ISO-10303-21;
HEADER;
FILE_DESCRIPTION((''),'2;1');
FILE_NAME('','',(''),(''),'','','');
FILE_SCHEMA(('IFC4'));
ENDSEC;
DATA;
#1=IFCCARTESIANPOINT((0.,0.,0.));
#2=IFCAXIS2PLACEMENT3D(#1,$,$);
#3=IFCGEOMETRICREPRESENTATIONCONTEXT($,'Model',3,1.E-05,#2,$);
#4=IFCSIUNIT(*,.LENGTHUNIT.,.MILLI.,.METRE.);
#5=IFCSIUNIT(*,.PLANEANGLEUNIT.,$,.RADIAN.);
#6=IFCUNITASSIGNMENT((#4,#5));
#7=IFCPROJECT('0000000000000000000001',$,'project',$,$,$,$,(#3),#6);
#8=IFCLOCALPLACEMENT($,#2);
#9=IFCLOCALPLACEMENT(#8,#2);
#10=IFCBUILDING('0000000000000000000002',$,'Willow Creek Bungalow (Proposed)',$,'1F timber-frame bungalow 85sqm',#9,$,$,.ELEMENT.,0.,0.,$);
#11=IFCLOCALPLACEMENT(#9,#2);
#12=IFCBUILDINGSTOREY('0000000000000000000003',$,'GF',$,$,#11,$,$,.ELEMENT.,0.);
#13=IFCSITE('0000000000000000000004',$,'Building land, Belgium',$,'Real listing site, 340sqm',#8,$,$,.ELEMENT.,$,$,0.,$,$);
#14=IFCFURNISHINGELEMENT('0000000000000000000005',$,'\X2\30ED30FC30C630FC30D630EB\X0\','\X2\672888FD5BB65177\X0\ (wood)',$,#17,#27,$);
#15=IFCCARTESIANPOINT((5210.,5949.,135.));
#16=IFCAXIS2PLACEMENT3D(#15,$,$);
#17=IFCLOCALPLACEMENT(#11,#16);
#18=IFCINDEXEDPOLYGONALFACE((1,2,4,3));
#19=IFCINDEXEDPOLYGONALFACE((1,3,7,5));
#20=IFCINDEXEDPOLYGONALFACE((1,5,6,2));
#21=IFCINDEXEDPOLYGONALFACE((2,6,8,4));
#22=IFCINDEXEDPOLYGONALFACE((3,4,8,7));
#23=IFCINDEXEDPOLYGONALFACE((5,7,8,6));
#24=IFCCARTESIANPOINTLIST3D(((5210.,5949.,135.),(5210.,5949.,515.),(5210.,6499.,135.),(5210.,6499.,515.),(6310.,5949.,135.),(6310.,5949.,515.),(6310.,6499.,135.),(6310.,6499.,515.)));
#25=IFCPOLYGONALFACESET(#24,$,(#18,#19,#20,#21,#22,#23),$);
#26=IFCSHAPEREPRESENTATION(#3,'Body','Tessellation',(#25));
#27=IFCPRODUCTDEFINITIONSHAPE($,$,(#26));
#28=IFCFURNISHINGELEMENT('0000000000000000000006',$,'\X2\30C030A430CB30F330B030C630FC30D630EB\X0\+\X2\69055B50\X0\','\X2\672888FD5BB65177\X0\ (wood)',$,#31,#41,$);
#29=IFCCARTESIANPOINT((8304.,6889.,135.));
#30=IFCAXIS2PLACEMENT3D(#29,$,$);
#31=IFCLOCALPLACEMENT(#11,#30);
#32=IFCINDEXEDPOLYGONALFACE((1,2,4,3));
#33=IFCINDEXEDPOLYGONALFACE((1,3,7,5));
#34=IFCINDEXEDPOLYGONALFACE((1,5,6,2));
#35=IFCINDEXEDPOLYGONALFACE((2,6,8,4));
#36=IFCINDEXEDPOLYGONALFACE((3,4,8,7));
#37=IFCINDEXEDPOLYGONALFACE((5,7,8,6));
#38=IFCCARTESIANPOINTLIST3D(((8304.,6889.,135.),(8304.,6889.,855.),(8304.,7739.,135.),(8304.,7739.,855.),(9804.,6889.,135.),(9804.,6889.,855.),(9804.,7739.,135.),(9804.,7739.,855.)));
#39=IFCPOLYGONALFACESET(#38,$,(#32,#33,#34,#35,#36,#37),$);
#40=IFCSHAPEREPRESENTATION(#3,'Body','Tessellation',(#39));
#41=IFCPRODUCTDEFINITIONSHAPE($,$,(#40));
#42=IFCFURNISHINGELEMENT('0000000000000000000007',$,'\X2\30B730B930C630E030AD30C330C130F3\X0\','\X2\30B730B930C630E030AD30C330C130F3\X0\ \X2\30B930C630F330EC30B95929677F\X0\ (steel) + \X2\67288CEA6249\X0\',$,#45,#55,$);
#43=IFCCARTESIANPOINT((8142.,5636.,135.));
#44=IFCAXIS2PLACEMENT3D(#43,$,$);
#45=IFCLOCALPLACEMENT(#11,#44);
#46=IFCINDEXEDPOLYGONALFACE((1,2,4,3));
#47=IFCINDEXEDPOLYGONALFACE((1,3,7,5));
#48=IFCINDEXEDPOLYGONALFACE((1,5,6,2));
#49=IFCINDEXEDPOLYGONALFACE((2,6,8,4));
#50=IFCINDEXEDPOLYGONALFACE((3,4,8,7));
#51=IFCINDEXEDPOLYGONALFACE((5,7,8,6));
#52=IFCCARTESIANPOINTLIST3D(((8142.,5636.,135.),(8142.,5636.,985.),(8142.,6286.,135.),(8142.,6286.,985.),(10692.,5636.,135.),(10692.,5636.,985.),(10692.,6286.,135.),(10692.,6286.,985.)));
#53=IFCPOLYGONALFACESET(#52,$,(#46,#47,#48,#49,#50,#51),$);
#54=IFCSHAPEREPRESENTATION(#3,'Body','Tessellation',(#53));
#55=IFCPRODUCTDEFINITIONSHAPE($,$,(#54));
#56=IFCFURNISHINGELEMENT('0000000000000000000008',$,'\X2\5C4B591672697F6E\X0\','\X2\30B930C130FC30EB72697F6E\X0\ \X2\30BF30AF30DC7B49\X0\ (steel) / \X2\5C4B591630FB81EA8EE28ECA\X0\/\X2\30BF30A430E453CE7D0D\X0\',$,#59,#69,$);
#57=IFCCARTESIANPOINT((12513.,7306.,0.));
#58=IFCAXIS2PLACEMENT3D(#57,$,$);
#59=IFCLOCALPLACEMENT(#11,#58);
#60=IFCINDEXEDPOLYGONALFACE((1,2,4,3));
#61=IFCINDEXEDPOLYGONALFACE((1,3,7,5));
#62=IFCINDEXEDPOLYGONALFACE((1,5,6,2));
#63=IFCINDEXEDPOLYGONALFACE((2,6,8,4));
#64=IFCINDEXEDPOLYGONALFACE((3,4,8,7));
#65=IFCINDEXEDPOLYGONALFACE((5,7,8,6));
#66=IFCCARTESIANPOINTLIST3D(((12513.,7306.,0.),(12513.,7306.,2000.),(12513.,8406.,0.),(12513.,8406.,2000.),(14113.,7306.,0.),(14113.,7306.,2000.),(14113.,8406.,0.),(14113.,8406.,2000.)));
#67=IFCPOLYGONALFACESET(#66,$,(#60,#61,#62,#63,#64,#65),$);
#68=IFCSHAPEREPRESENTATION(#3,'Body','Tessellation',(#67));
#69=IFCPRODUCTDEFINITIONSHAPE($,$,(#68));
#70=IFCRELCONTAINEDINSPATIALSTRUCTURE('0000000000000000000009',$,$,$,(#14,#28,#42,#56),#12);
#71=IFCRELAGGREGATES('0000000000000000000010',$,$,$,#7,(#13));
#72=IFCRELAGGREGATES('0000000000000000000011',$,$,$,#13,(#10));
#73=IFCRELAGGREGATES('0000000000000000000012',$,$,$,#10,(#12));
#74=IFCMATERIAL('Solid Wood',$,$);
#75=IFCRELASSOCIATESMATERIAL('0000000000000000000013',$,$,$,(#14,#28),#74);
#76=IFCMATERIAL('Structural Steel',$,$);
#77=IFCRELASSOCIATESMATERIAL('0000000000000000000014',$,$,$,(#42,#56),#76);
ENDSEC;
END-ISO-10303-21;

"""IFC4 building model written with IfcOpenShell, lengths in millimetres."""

from ifc_helpers import new_model, si_unit, frame, frame_2d, origin, place, context, project, spatial, rectangle, extrude, material, element, save


model = new_model("IFC4")

# Units and contexts
model_context = context("Model", 3, precision=1e-05, world=origin())
ifc_project = project(units=[si_unit("LENGTHUNIT", "METRE", prefix="MILLI"), si_unit("PLANEANGLEUNIT", "RADIAN")], contexts=[model_context])

# Site, building, storey
site_placement = place(None, origin())
site = spatial("IfcSite", under=ifc_project, at=site_placement, Name="Building land, Belgium", ObjectType="Real listing site, 340sqm", CompositionType="ELEMENT", RefElevation=0.0)
building_placement = place(site_placement, origin())
building = spatial("IfcBuilding", under=site, at=building_placement, Name="Willow Creek Bungalow (Proposed)", ObjectType="1F timber-frame bungalow 85sqm", CompositionType="ELEMENT", ElevationOfRefHeight=0.0, ElevationOfTerrain=0.0)
storey_placement = place(building_placement, origin())
storey = spatial("IfcBuildingStorey", under=building, at=storey_placement, Name="GF", CompositionType="ELEMENT", Elevation=0.0)

# Shared definitions
ifc_material_1 = material(Name="Solid Wood")

# Shared definitions
ifc_material_2 = material(Name="Structural Steel")

# Furnishing elements
furnishing_1_placement = place(storey_placement, frame((5210.0, 5949.0, 135.0)))
element("IfcFurnishingElement", 1, at=furnishing_1_placement, inside=storey, material=ifc_material_1, Name="ローテーブル", Description="木製家具 (wood)", context=model_context, shape_type="SweptSolid", body=[
    extrude(rectangle(XDim=1100.0, YDim=550.0, at=frame_2d((550.0, 275.0))), frame((5210.0, 5949.0, 135.0)), (0.0, 0.0, 1.0), 380.0),
])
furnishing_2_placement = place(storey_placement, frame((8304.0, 6889.0, 135.0)))
element("IfcFurnishingElement", 2, at=furnishing_2_placement, inside=storey, material=ifc_material_1, Name="ダイニングテーブル+椅子", Description="木製家具 (wood)", context=model_context, shape_type="SweptSolid", body=[
    extrude(rectangle(XDim=1500.0, YDim=850.0, at=frame_2d((750.0, 425.0))), frame((8304.0, 6889.0, 135.0)), (0.0, 0.0, 1.0), 720.0),
])
furnishing_3_placement = place(storey_placement, frame((8142.0, 5636.0, 135.0)))
element("IfcFurnishingElement", 3, at=furnishing_3_placement, inside=storey, material=ifc_material_2, Name="システムキッチン", Description="システムキッチン ステンレス天板 (steel) + 木質扉", context=model_context, shape_type="SweptSolid", body=[
    extrude(rectangle(XDim=2550.0, YDim=650.0, at=frame_2d((1275.0, 325.0))), frame((8142.0, 5636.0, 135.0)), (0.0, 0.0, 1.0), 850.0),
])
furnishing_4_placement = place(storey_placement, frame((12513.0, 7306.0, 0.0)))
element("IfcFurnishingElement", 4, at=furnishing_4_placement, inside=storey, material=ifc_material_2, Name="屋外物置", Description="スチール物置 タクボ等 (steel) / 屋外・自転車/タイヤ収納", context=model_context, shape_type="SweptSolid", body=[
    extrude(rectangle(XDim=1600.0, YDim=1100.0, at=frame_2d((800.0, 550.0))), frame((12513.0, 7306.0, 0.0)), (0.0, 0.0, 1.0), 2000.0),
])

save(model, "model.ifc")
